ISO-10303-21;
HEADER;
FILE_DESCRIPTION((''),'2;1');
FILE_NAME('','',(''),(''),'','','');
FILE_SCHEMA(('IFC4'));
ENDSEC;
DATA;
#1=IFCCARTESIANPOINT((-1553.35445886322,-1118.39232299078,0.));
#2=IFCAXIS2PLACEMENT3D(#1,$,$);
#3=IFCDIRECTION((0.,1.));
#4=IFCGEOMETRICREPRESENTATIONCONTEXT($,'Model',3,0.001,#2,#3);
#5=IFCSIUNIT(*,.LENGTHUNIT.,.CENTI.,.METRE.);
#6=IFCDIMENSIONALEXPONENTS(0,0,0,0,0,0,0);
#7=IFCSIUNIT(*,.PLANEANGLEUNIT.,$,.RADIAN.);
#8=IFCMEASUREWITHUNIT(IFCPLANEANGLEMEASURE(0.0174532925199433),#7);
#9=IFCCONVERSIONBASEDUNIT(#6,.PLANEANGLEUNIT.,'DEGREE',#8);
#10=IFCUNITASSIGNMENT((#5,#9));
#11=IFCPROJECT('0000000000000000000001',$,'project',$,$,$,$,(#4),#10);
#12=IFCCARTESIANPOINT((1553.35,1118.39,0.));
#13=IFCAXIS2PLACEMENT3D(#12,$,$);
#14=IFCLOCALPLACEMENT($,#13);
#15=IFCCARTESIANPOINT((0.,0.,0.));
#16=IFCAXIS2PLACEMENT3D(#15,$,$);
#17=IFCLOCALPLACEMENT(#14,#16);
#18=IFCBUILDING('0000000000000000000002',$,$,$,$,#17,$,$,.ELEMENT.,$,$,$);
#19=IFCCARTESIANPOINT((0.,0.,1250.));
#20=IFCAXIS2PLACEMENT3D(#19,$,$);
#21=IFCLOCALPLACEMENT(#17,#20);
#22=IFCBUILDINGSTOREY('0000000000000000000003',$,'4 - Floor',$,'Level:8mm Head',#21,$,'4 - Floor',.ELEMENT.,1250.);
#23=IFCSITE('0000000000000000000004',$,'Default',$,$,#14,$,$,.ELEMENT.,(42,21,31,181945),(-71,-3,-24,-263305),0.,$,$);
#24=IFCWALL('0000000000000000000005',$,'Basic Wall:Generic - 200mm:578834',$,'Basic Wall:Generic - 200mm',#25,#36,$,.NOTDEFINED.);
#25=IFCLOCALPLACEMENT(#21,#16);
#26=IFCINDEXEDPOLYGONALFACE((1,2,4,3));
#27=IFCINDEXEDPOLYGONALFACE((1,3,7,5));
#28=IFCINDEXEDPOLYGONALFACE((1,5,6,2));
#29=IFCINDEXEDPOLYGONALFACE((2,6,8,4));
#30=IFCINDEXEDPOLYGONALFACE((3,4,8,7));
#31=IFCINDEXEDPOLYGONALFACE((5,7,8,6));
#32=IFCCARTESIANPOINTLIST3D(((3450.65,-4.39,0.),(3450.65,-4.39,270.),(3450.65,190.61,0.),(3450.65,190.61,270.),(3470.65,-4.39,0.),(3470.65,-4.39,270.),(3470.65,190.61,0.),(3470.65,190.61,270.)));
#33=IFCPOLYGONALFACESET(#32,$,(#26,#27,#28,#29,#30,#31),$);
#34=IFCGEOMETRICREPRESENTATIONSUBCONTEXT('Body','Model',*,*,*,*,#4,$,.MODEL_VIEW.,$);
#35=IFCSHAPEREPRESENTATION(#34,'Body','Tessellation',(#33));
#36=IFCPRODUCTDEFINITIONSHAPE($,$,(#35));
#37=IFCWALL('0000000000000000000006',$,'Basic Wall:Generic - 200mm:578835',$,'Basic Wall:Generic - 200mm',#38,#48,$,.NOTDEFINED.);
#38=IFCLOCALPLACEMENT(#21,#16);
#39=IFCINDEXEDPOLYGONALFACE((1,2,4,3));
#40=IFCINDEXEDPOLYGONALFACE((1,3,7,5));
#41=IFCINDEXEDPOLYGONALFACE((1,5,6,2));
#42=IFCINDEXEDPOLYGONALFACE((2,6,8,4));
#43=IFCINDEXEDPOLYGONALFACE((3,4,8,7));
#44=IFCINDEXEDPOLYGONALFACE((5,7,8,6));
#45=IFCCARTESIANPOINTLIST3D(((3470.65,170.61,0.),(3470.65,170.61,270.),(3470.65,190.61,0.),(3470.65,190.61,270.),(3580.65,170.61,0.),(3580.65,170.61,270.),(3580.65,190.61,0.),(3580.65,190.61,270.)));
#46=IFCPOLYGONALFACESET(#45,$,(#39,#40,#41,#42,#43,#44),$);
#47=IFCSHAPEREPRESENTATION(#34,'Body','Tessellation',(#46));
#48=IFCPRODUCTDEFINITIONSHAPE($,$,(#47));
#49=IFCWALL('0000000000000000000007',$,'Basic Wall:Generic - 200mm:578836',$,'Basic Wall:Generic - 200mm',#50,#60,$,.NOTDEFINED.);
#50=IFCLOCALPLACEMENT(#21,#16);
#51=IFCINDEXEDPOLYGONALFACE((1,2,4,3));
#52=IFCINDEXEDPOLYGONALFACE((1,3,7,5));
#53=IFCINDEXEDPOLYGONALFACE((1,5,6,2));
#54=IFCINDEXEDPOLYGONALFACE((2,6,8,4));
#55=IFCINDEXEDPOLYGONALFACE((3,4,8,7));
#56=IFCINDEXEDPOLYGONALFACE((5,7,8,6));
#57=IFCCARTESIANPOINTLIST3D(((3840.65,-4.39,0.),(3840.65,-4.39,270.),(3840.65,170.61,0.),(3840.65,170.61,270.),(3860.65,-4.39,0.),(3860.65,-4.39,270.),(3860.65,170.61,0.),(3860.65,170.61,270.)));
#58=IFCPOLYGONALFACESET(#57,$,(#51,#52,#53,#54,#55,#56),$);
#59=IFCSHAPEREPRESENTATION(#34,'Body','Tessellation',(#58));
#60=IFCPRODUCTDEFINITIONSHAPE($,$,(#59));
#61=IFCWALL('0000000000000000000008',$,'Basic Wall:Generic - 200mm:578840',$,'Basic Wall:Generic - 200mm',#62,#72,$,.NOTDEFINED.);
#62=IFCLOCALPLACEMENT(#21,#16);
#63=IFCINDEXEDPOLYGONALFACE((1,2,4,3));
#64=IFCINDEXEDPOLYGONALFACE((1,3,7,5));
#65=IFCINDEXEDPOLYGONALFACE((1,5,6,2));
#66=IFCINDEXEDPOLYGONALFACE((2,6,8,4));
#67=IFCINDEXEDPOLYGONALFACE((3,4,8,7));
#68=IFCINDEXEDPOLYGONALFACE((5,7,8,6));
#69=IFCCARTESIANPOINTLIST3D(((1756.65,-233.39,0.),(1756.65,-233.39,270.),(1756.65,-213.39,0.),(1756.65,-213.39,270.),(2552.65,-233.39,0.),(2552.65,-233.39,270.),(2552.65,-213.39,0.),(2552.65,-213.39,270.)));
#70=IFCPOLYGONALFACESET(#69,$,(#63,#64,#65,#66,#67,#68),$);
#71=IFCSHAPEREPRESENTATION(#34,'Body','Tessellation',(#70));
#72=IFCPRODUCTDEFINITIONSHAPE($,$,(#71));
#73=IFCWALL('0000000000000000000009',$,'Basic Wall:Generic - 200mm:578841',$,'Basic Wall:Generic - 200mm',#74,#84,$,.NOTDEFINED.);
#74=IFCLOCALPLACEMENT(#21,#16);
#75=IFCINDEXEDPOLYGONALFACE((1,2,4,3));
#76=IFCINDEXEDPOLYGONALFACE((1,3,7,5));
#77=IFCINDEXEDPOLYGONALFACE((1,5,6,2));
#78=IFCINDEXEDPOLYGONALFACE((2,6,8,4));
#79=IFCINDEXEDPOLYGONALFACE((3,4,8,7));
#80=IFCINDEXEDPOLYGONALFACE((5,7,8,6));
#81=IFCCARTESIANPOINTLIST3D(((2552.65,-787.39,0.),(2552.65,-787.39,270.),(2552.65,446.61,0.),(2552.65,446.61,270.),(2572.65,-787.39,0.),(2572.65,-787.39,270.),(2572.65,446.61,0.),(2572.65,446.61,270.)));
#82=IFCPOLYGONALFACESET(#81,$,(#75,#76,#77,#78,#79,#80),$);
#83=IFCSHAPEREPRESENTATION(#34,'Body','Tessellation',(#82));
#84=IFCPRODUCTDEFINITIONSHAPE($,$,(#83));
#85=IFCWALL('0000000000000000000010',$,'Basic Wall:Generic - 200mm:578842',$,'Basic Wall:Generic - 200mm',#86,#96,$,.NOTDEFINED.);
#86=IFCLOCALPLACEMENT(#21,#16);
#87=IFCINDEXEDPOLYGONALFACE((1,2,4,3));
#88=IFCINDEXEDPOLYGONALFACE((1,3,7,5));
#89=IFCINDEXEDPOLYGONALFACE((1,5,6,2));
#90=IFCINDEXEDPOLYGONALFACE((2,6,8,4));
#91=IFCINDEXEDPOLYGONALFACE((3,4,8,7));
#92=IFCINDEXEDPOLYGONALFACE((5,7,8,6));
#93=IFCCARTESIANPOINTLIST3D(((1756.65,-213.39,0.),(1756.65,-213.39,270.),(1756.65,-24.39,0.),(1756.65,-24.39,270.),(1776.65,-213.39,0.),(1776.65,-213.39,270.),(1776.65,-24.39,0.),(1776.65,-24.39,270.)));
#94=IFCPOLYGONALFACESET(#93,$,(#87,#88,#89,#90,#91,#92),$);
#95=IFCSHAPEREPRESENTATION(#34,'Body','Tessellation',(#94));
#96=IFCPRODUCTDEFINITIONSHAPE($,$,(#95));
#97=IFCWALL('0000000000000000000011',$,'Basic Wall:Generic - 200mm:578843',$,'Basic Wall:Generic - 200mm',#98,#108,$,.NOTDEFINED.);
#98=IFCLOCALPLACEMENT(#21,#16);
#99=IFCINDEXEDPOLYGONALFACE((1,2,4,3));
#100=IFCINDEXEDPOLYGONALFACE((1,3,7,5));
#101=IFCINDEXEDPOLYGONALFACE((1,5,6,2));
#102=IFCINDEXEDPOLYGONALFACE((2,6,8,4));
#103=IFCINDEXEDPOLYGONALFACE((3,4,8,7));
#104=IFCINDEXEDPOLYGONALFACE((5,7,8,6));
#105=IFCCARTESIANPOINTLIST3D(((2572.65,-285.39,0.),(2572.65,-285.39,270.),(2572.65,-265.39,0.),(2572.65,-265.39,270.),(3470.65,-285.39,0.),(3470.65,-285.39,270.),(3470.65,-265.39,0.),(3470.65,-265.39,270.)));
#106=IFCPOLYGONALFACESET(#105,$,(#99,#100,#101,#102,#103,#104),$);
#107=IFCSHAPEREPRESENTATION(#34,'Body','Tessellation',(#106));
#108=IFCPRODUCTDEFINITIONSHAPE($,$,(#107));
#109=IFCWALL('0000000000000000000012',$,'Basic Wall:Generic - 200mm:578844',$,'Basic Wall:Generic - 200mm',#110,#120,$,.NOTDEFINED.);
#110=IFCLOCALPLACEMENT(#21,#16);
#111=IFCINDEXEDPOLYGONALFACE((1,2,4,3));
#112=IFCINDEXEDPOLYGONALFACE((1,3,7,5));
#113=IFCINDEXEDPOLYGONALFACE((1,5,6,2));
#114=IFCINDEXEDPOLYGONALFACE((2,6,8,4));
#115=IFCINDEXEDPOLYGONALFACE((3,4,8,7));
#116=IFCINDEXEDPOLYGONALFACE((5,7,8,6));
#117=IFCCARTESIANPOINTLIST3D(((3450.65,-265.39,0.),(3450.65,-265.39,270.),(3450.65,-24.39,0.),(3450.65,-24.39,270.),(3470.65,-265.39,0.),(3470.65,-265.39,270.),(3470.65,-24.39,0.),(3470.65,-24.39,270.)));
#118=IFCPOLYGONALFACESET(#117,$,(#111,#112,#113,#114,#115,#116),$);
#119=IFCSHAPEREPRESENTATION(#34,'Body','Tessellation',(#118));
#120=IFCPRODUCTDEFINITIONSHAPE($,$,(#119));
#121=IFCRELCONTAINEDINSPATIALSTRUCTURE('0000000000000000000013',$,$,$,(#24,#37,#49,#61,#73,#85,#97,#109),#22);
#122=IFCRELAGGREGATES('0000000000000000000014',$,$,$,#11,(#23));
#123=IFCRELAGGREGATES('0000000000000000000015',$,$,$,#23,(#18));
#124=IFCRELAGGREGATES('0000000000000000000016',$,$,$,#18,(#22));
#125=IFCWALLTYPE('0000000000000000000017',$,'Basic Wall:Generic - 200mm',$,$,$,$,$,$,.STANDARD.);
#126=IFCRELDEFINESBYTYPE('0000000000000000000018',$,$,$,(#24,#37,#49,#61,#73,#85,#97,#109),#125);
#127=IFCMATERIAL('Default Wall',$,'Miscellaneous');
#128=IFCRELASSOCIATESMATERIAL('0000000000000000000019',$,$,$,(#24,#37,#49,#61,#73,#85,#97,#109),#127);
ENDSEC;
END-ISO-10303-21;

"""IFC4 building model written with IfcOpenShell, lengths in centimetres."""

from ifc_helpers import new_model, entity, si_unit, converted_unit, direction, frame, origin, place, context, subcontext, project, spatial, indexed_curve, outline, extrude, material, type_object, element, save


model = new_model("IFC4")

# Units and contexts
model_context = context("Model", 3, precision=0.001, world=frame((-1553.35445886322, -1118.39232299078, 0.0)), true_north=direction((0.0, 1.0)))
body_context = subcontext(model_context, "Body", "Model", "MODEL_VIEW")
ifc_project = project(units=[si_unit("LENGTHUNIT", "METRE", prefix="CENTI"), converted_unit("PLANEANGLEUNIT", "DEGREE", entity("IfcPlaneAngleMeasure", 0.0174532925199433), si_unit("PLANEANGLEUNIT", "RADIAN"), dimensions=[0, 0, 0, 0, 0, 0, 0])], contexts=[model_context])

# Site, building, storey
site_placement = place(None, frame((1553.35, 1118.39, 0.0)))
site = spatial("IfcSite", under=ifc_project, at=site_placement, Name="Default", CompositionType="ELEMENT", RefLatitude=(42, 21, 31, 181945), RefLongitude=(-71, -3, -24, -263305), RefElevation=0.0)
building_placement = place(site_placement, origin())
building = spatial("IfcBuilding", under=site, at=building_placement, CompositionType="ELEMENT")
storey_placement = place(building_placement, frame((0.0, 0.0, 1250.0)))
storey = spatial("IfcBuildingStorey", under=building, at=storey_placement, Name="4 - Floor", ObjectType="Level:8mm Head", LongName="4 - Floor", CompositionType="ELEMENT", Elevation=1250.0)

# Walls
ifc_material_1 = material(Name="Default Wall", Category="Miscellaneous")
wall_type_1 = type_object("IfcWallType", Name="Basic Wall:Generic - 200mm", PredefinedType="STANDARD")
wall_1_placement = place(storey_placement, frame((3460.65, -4.39, 0.0), z_axis=(0.0, 0.0, 1.0), x_axis=(0.0, 1.0, 0.0)))
element("IfcWall", 1, at=wall_1_placement, inside=storey, type_object=wall_type_1, material=ifc_material_1, Name="Basic Wall:Generic - 200mm:578834", ObjectType="Basic Wall:Generic - 200mm", PredefinedType="NOTDEFINED", context=body_context, shape_type="SweptSolid", body=[
    extrude(outline(indexed_curve([(195.0, 10.0), (0.0, 10.0), (0.0, -10.0), (195.0, -10.0), (195.0, 10.0)], self_intersect=False)), origin(), (0.0, 0.0, 1.0), 270.0),
])
wall_2_placement = place(storey_placement, frame((3470.65, 180.61, 0.0)))
element("IfcWall", 2, at=wall_2_placement, inside=storey, type_object=wall_type_1, material=ifc_material_1, Name="Basic Wall:Generic - 200mm:578835", ObjectType="Basic Wall:Generic - 200mm", PredefinedType="NOTDEFINED", context=body_context, shape_type="SweptSolid", body=[
    extrude(outline(indexed_curve([(110.0, 10.0), (0.0, 10.0), (0.0, -10.0), (110.0, -10.0), (110.0, 10.0)], self_intersect=False)), origin(), (0.0, 0.0, 1.0), 270.0),
])
wall_3_placement = place(storey_placement, frame((3850.65, 170.61, 0.0), z_axis=(0.0, 0.0, 1.0), x_axis=(0.0, -1.0, 0.0)))
element("IfcWall", 3, at=wall_3_placement, inside=storey, type_object=wall_type_1, material=ifc_material_1, Name="Basic Wall:Generic - 200mm:578836", ObjectType="Basic Wall:Generic - 200mm", PredefinedType="NOTDEFINED", context=body_context, shape_type="SweptSolid", body=[
    extrude(outline(indexed_curve([(175.0, 10.0), (0.0, 10.0), (0.0, -10.0), (175.0, -10.0), (175.0, 10.0)], self_intersect=False)), origin(), (0.0, 0.0, 1.0), 270.0),
])
wall_4_placement = place(storey_placement, frame((1756.65, -223.39, 0.0)))
element("IfcWall", 4, at=wall_4_placement, inside=storey, type_object=wall_type_1, material=ifc_material_1, Name="Basic Wall:Generic - 200mm:578840", ObjectType="Basic Wall:Generic - 200mm", PredefinedType="NOTDEFINED", context=body_context, shape_type="SweptSolid", body=[
    extrude(outline(indexed_curve([(796.0, 10.0), (0.0, 10.0), (0.0, -10.0), (796.0, -10.0), (796.0, 10.0)], self_intersect=False)), origin(), (0.0, 0.0, 1.0), 270.0),
])
wall_5_placement = place(storey_placement, frame((2562.65, 446.61, 0.0), z_axis=(0.0, 0.0, 1.0), x_axis=(0.0, -1.0, 0.0)))
element("IfcWall", 5, at=wall_5_placement, inside=storey, type_object=wall_type_1, material=ifc_material_1, Name="Basic Wall:Generic - 200mm:578841", ObjectType="Basic Wall:Generic - 200mm", PredefinedType="NOTDEFINED", context=body_context, shape_type="SweptSolid", body=[
    extrude(outline(indexed_curve([(1234.0, 10.0), (0.0, 10.0), (0.0, -10.0), (1234.0, -10.0), (1234.0, 10.0)], self_intersect=False)), origin(), (0.0, 0.0, 1.0), 270.0),
])
wall_6_placement = place(storey_placement, frame((1766.65, -24.39, 0.0), z_axis=(0.0, 0.0, 1.0), x_axis=(0.0, -1.0, 0.0)))
element("IfcWall", 6, at=wall_6_placement, inside=storey, type_object=wall_type_1, material=ifc_material_1, Name="Basic Wall:Generic - 200mm:578842", ObjectType="Basic Wall:Generic - 200mm", PredefinedType="NOTDEFINED", context=body_context, shape_type="SweptSolid", body=[
    extrude(outline(indexed_curve([(189.0, 10.0), (0.0, 10.0), (0.0, -10.0), (189.0, -10.0), (189.0, 10.0)], self_intersect=False)), origin(), (0.0, 0.0, 1.0), 270.0),
])
wall_7_placement = place(storey_placement, frame((2572.65, -275.39, 0.0)))
element("IfcWall", 7, at=wall_7_placement, inside=storey, type_object=wall_type_1, material=ifc_material_1, Name="Basic Wall:Generic - 200mm:578843", ObjectType="Basic Wall:Generic - 200mm", PredefinedType="NOTDEFINED", context=body_context, shape_type="SweptSolid", body=[
    extrude(outline(indexed_curve([(898.0, 10.0), (0.0, 10.0), (0.0, -10.0), (898.0, -10.0), (898.0, 10.0)], self_intersect=False)), origin(), (0.0, 0.0, 1.0), 270.0),
])
wall_8_placement = place(storey_placement, frame((3460.65, -24.39, 0.0), z_axis=(0.0, 0.0, 1.0), x_axis=(0.0, -1.0, 0.0)))
element("IfcWall", 8, at=wall_8_placement, inside=storey, type_object=wall_type_1, material=ifc_material_1, Name="Basic Wall:Generic - 200mm:578844", ObjectType="Basic Wall:Generic - 200mm", PredefinedType="NOTDEFINED", context=body_context, shape_type="SweptSolid", body=[
    extrude(outline(indexed_curve([(241.0, 10.0), (0.0, 10.0), (0.0, -10.0), (241.0, -10.0), (241.0, 10.0)], self_intersect=False)), origin(), (0.0, 0.0, 1.0), 270.0),
])

save(model, "model.ifc")
